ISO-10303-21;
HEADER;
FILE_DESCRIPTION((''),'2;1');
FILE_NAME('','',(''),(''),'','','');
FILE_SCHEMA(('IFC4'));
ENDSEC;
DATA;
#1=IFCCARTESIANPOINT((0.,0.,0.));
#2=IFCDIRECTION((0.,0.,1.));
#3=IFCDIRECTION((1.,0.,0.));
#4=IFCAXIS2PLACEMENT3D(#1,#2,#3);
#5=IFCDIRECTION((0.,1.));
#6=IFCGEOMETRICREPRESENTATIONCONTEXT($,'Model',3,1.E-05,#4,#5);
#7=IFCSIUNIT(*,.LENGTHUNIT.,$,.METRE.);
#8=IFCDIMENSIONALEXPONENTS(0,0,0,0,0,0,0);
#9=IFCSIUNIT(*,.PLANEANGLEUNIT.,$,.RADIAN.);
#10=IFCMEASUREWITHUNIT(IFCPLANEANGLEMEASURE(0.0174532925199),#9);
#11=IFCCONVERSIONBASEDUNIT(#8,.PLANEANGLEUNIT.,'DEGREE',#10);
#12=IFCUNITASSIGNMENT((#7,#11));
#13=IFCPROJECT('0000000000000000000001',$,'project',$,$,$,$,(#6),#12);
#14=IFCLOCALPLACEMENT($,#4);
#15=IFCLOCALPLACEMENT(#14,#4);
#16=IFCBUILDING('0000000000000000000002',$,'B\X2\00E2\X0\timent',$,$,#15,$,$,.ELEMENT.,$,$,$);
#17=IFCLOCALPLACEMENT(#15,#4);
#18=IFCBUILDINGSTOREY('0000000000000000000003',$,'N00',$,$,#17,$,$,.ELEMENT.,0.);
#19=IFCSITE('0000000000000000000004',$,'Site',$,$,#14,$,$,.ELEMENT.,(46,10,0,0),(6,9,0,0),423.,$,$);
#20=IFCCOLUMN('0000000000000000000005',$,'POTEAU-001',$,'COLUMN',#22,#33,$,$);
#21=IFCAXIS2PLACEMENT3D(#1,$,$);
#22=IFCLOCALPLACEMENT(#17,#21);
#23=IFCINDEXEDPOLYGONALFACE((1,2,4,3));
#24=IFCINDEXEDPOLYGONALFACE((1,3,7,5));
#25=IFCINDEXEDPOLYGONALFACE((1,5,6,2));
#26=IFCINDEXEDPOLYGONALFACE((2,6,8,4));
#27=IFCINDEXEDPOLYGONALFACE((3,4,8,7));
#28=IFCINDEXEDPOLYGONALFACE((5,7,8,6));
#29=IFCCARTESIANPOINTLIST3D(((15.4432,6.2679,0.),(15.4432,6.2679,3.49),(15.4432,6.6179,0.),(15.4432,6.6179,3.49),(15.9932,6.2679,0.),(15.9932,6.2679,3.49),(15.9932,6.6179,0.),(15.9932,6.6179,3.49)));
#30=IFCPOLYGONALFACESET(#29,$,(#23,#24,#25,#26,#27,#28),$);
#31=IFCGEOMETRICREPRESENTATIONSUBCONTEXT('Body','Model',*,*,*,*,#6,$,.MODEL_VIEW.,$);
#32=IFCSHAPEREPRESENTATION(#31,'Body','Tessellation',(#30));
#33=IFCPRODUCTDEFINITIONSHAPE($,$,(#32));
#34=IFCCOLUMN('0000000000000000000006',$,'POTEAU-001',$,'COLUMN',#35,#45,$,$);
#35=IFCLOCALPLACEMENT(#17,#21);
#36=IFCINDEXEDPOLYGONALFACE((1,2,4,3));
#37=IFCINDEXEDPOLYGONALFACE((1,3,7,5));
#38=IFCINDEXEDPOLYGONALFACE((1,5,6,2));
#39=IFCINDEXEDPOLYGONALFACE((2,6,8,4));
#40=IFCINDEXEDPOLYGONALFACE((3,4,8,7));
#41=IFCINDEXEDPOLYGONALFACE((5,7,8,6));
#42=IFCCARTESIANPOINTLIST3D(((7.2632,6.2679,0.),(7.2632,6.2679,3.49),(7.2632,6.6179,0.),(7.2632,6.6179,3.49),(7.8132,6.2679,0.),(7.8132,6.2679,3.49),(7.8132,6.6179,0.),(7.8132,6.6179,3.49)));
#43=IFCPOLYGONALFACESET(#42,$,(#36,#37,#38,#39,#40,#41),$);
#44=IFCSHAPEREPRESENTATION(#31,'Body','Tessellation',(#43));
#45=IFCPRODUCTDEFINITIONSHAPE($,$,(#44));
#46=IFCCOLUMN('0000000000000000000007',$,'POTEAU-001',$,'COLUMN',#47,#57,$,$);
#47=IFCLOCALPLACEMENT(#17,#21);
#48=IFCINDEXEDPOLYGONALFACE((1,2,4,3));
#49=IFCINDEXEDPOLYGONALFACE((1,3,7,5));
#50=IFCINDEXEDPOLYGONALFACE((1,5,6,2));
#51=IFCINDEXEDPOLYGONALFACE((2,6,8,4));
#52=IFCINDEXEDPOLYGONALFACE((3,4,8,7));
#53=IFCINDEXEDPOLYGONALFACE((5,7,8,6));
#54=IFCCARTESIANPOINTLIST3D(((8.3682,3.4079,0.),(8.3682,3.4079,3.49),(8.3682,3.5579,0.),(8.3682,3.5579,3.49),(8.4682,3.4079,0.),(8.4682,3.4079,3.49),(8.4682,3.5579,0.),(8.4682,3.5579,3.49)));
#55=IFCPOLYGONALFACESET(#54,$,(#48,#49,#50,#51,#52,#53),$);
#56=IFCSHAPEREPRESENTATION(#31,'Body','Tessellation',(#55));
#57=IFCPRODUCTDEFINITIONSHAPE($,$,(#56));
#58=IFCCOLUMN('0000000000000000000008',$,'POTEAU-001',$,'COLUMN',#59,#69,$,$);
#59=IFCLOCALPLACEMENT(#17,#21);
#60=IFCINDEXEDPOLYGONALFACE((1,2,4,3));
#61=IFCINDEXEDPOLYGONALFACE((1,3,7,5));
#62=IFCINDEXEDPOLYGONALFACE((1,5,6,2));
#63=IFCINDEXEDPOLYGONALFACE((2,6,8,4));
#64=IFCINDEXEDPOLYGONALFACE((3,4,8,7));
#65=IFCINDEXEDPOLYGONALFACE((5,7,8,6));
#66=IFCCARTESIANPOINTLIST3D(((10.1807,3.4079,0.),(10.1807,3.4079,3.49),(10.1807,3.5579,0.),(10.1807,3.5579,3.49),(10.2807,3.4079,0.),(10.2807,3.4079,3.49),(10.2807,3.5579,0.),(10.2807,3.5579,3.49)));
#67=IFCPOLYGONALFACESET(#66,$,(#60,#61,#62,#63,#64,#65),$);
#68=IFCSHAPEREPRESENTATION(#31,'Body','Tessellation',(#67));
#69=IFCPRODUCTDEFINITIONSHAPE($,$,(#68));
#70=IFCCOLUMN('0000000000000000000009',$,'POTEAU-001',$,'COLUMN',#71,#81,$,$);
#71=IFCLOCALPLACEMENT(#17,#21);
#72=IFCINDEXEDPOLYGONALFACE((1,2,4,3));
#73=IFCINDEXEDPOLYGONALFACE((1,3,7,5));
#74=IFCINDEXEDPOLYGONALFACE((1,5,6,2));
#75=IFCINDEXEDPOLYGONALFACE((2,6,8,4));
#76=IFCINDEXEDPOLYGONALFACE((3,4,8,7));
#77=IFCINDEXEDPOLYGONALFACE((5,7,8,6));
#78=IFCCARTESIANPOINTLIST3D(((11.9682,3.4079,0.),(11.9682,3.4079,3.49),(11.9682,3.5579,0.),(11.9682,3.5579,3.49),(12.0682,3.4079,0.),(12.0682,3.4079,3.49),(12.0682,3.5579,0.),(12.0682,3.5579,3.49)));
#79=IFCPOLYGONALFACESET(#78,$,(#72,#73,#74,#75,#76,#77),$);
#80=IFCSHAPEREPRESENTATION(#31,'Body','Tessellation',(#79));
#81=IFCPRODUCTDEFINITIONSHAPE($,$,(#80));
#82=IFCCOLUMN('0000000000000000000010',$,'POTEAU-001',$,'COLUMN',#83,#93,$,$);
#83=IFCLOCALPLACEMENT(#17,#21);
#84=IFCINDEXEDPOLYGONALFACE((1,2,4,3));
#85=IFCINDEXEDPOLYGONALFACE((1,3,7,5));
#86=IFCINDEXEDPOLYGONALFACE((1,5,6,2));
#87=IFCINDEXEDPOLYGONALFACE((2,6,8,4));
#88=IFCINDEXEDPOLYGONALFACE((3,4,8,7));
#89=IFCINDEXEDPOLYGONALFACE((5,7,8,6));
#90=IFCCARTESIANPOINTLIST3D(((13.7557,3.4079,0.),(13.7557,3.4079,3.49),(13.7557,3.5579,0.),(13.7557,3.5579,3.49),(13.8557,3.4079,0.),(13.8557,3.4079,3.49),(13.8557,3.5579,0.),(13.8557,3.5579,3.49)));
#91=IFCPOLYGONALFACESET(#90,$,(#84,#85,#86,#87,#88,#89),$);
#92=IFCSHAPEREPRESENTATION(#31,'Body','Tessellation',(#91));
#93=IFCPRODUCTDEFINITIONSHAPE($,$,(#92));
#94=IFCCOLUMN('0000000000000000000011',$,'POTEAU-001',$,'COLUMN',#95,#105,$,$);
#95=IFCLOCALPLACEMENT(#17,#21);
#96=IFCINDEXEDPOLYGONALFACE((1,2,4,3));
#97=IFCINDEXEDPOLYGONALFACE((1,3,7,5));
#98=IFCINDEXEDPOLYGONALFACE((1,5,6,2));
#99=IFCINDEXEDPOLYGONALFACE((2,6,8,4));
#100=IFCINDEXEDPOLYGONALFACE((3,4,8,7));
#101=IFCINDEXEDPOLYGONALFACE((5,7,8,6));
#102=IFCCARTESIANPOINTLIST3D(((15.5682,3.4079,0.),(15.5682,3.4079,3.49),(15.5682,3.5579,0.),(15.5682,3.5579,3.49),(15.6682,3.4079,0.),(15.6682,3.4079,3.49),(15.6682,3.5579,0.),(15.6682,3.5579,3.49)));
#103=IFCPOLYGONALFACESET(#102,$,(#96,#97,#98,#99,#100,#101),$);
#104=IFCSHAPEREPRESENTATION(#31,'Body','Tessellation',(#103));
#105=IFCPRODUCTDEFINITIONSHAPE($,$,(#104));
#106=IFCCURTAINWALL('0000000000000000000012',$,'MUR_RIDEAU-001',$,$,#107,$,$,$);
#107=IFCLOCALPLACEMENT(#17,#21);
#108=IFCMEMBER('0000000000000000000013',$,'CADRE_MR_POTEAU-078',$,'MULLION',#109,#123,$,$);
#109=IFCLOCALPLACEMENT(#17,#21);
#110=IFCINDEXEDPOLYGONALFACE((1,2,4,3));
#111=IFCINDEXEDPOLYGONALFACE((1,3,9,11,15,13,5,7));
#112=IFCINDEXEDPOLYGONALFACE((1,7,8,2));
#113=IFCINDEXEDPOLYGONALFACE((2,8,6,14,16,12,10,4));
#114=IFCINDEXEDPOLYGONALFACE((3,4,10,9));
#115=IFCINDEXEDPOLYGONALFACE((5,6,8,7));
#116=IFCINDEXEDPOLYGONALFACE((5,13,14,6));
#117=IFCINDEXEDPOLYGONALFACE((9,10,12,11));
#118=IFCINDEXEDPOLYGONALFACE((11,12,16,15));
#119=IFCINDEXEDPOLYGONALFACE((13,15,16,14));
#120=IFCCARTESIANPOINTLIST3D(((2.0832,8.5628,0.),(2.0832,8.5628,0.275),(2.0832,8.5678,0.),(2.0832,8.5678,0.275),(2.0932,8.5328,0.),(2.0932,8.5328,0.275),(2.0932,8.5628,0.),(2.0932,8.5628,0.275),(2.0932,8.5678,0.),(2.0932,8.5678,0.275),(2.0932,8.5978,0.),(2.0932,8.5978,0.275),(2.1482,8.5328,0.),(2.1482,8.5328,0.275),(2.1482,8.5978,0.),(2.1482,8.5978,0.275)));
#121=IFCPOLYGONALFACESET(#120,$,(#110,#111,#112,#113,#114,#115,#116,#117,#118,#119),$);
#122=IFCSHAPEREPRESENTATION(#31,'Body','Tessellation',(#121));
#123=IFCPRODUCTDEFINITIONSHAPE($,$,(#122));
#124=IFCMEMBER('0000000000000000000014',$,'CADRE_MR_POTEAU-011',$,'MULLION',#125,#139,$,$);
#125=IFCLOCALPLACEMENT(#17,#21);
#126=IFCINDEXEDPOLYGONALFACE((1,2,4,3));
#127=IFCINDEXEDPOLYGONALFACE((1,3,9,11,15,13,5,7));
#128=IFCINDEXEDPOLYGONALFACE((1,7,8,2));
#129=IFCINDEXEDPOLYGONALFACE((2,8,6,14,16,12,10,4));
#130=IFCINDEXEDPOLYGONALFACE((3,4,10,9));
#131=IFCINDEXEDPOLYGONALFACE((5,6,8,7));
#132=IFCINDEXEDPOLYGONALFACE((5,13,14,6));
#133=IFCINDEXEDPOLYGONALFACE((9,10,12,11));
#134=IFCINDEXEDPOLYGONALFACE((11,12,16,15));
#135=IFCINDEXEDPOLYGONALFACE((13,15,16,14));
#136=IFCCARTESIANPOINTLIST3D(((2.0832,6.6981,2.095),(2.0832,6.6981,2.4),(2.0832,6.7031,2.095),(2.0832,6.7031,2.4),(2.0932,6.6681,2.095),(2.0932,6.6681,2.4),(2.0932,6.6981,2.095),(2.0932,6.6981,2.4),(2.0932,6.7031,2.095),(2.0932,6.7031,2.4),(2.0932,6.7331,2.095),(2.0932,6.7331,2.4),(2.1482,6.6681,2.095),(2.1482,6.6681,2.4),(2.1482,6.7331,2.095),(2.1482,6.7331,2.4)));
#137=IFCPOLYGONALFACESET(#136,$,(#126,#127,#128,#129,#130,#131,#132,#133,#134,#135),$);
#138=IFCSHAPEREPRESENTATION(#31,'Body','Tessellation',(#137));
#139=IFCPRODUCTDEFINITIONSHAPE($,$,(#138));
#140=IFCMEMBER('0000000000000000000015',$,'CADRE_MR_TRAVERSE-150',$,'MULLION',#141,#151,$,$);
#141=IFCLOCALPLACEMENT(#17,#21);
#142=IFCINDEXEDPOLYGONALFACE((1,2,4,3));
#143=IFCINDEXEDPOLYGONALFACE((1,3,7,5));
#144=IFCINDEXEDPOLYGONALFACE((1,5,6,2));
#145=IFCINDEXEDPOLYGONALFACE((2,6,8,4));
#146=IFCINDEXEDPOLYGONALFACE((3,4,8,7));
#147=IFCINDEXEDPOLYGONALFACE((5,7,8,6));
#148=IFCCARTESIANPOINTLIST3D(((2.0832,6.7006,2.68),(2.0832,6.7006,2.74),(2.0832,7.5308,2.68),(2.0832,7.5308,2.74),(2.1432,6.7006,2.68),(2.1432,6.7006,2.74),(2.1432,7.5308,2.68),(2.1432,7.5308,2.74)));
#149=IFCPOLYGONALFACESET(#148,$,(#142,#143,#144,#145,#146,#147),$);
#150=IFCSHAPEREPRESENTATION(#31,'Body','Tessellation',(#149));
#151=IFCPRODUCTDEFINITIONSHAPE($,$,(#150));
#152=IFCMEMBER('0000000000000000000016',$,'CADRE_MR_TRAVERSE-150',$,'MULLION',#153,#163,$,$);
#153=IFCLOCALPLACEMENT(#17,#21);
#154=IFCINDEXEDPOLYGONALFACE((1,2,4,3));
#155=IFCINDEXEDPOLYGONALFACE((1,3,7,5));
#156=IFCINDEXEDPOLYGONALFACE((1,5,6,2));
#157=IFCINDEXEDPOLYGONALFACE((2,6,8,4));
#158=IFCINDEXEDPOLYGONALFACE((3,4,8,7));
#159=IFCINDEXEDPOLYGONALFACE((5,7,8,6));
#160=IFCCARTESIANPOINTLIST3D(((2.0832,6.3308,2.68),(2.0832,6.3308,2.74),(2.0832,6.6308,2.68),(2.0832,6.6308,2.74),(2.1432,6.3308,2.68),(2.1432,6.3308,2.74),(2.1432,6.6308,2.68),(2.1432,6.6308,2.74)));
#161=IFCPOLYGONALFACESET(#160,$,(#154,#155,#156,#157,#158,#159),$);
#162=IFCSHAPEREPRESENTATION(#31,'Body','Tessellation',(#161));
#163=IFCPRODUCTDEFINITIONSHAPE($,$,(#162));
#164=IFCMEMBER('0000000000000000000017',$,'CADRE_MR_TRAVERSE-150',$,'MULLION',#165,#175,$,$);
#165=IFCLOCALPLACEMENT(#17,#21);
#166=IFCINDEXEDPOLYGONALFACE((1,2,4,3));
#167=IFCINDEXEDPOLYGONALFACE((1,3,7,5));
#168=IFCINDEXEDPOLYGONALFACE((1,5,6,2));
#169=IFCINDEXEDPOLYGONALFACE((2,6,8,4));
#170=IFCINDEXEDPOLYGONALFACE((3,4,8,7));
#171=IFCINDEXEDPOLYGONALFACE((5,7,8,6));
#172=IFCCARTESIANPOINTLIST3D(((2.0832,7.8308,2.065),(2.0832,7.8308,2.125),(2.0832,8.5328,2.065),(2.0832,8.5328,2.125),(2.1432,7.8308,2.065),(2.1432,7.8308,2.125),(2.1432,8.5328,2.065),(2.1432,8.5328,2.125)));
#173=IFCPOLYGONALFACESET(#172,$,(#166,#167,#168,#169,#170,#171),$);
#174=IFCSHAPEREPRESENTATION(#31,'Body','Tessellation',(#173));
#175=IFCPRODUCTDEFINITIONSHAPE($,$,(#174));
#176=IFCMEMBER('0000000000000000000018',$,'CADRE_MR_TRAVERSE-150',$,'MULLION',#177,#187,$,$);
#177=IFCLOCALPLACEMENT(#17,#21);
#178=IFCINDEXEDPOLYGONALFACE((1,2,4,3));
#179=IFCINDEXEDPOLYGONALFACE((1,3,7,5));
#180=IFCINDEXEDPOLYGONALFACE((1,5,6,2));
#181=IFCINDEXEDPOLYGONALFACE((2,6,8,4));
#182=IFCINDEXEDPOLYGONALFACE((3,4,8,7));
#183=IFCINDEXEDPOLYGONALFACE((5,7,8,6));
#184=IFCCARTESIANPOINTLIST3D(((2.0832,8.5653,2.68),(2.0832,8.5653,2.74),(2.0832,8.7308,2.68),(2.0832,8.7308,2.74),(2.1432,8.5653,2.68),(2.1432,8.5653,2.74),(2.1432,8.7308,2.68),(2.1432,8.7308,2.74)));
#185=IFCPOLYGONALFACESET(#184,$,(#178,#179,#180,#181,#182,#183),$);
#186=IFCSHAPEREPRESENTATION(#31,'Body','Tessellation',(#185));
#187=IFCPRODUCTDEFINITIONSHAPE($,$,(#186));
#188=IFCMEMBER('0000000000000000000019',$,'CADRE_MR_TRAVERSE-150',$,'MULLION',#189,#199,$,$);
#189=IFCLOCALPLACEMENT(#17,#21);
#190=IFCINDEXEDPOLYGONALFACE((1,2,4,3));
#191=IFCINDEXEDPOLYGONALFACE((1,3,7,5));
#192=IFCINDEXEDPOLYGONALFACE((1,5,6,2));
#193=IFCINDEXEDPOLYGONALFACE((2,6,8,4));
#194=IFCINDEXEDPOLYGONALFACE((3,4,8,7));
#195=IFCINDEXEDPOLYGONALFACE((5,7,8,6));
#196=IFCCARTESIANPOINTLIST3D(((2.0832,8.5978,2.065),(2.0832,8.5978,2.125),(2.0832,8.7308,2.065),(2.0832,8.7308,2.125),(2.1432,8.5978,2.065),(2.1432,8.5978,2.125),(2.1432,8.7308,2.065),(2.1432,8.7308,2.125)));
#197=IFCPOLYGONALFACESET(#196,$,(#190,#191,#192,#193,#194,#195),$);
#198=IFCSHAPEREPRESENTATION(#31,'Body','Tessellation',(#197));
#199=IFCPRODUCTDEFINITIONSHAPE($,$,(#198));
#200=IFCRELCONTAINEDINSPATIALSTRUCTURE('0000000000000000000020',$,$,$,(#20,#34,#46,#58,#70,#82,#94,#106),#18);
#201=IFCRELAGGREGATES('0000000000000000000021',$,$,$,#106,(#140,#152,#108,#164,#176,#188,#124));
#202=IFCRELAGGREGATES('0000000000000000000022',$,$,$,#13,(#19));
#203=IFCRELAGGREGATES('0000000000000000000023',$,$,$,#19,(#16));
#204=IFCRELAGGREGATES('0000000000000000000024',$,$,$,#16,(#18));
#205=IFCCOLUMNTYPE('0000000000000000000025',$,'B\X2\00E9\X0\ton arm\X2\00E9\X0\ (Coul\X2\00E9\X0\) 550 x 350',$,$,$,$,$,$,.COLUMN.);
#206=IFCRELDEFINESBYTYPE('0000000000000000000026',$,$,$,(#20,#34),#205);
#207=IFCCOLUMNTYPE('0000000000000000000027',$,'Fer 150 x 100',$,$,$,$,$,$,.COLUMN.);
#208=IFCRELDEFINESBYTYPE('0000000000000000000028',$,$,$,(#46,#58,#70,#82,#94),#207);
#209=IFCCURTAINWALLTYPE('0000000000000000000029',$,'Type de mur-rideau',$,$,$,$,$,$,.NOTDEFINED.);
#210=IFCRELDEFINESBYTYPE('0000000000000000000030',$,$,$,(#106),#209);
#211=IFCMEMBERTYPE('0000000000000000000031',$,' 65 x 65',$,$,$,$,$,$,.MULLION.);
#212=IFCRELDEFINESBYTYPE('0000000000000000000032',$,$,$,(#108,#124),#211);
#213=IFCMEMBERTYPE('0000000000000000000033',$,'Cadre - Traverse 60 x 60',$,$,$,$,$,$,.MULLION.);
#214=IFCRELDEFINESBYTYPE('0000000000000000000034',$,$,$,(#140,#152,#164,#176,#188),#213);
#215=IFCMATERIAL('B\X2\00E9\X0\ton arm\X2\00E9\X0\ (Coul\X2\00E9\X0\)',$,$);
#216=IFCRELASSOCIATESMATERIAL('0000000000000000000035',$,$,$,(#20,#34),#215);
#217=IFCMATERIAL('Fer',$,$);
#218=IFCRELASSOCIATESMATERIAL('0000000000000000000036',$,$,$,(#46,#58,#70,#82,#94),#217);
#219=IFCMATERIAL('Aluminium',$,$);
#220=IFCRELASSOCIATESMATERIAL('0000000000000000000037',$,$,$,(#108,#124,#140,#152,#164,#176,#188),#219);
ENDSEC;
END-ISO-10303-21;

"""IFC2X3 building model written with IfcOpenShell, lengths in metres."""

from ifc_helpers import new_model, entity, si_unit, converted_unit, direction, frame, origin_with_axes, origin_2d_with_axis, place, context, subcontext, project, spatial, polyline, rectangle, outline, extrude, material, type_object, element, aggregate, save


model = new_model("IFC2X3")

# Units and contexts
model_context = context("Model", 3, precision=1e-05, world=origin_with_axes(), true_north=direction((0.0, 1.0)))
body_context = subcontext(model_context, "Body", "Model", "MODEL_VIEW")
ifc_project = project(units=[si_unit("LENGTHUNIT", "METRE"), converted_unit("PLANEANGLEUNIT", "DEGREE", entity("IfcPlaneAngleMeasure", 0.0174532925199), si_unit("PLANEANGLEUNIT", "RADIAN"), dimensions=[0, 0, 0, 0, 0, 0, 0])], contexts=[model_context])

# Site, building, storey
site_placement = place(None, origin_with_axes())
site = spatial("IfcSite", under=ifc_project, at=site_placement, Name="Site", CompositionType="ELEMENT", RefLatitude=(46, 10, 0, 0), RefLongitude=(6, 9, 0, 0), RefElevation=423.0)
building_placement = place(site_placement, origin_with_axes())
building = spatial("IfcBuilding", under=site, at=building_placement, Name="Bâtiment", CompositionType="ELEMENT")
storey_placement = place(building_placement, origin_with_axes())
storey = spatial("IfcBuildingStorey", under=building, at=storey_placement, Name="N00", CompositionType="ELEMENT", Elevation=0.0)

# Columns
ifc_material_1 = material(Name="Béton armé (Coulé)")
column_type_1 = type_object("IfcColumnType", Name="Béton armé (Coulé) 550 x 350", PredefinedType="COLUMN")
for number, where, z_axis, x_axis, name in (
    (1, (15.7182, 6.4429, 0.0), (0.0, 0.0, 1.0), (1.0, 0.0, 0.0), "POTEAU-001"),
    (2, (7.5382, 6.4429, 0.0), (0.0, 0.0, 1.0), (1.0, 0.0, 0.0), "POTEAU-001"),
):
    element("IfcColumn", number, at=place(storey_placement, frame(where, z_axis=z_axis, x_axis=x_axis)), inside=storey, type_object=column_type_1, material=ifc_material_1, Name=name, ObjectType="COLUMN", context=body_context, shape_type="SweptSolid", body=[
        extrude(rectangle(XDim=0.55, YDim=0.35, at=origin_2d_with_axis()), origin_with_axes(), (0.0, 0.0, 1.0), 3.49),
    ])
ifc_material_2 = material(Name="Fer")
column_type_2 = type_object("IfcColumnType", Name="Fer 150 x 100", PredefinedType="COLUMN")
for number, where, z_axis, x_axis, name in (
    (3, (8.4182, 3.4829, 0.0), (0.0, 0.0, 1.0), (0.0, 1.0, 0.0), "POTEAU-001"),
    (4, (10.2307, 3.4829, 0.0), (0.0, 0.0, 1.0), (0.0, 1.0, 0.0), "POTEAU-001"),
    (5, (12.0182, 3.4829, 0.0), (0.0, 0.0, 1.0), (0.0, 1.0, 0.0), "POTEAU-001"),
    (6, (13.8057, 3.4829, 0.0), (0.0, 0.0, 1.0), (0.0, 1.0, 0.0), "POTEAU-001"),
    (7, (15.6182, 3.4829, 0.0), (0.0, 0.0, 1.0), (0.0, 1.0, 0.0), "POTEAU-001"),
):
    element("IfcColumn", number, at=place(storey_placement, frame(where, z_axis=z_axis, x_axis=x_axis)), inside=storey, type_object=column_type_2, material=ifc_material_2, Name=name, ObjectType="COLUMN", context=body_context, shape_type="SweptSolid", body=[
        extrude(rectangle(XDim=0.15, YDim=0.1, at=origin_2d_with_axis()), origin_with_axes(), (0.0, 0.0, 1.0), 3.49),
    ])

# Curtain wall, members
curtain_wall_type = type_object("IfcCurtainWallType", Name="Type de mur-rideau", PredefinedType="NOTDEFINED")
curtain_wall_placement = place(storey_placement, frame((2.0832, 6.4208, 0.0), z_axis=(0.0, 0.0, 1.0), x_axis=(1.0, 0.0, 0.0)))
curtain_wall = element("IfcCurtainWall", 8, at=curtain_wall_placement, inside=storey, type_object=curtain_wall_type, Name="MUR_RIDEAU-001")
ifc_material_3 = material(Name="Aluminium")
member_type_1 = type_object("IfcMemberType", Name=" 65 x 65", PredefinedType="MULLION")
member_1_placement = place(curtain_wall_placement, frame((0.0, 2.1445, 0.0), z_axis=(0.0, 0.0, 1.0), x_axis=(0.0, 1.0, 0.0)))
member_1 = element("IfcMember", 9, at=member_1_placement, type_object=member_type_1, material=ifc_material_3, Name="CADRE_MR_POTEAU-078", ObjectType="MULLION", context=body_context, shape_type="SweptSolid", body=[
    extrude(outline(polyline([(0.01, -0.0025), (0.01, -0.0325), (0.065, -0.0325), (0.065, 0.0325), (0.01, 0.0325), (0.01, 0.0025), (0.0, 0.0025), (0.0, -0.0025), (0.01, -0.0025)])), frame((0.0, 0.0, 0.0), z_axis=(0.0, 0.0, 1.0), x_axis=(0.0, -1.0, 0.0)), (0.0, 0.0, 1.0), 0.275),
])
member_2_placement = place(curtain_wall_placement, frame((0.0, 0.2798, 2.095), z_axis=(0.0, 0.0, 1.0), x_axis=(0.0, 1.0, 0.0)))
member_2 = element("IfcMember", 10, at=member_2_placement, type_object=member_type_1, material=ifc_material_3, Name="CADRE_MR_POTEAU-011", ObjectType="MULLION", context=body_context, shape_type="SweptSolid", body=[
    extrude(outline(polyline([(0.01, -0.0025), (0.01, -0.0325), (0.065, -0.0325), (0.065, 0.0325), (0.01, 0.0325), (0.01, 0.0025), (0.0, 0.0025), (0.0, -0.0025), (0.01, -0.0025)])), frame((0.0, 0.0, 0.0), z_axis=(0.0, 0.0, 1.0), x_axis=(0.0, -1.0, 0.0)), (0.0, 0.0, 1.0), 0.305),
])
member_type_2 = type_object("IfcMemberType", Name="Cadre - Traverse 60 x 60", PredefinedType="MULLION")
member_3_placement = place(curtain_wall_placement, frame((0.0, 1.1099, 2.71), z_axis=(0.0, -1.0, 0.0), x_axis=(0.0, 0.0, 1.0)))
member_3 = element("IfcMember", 11, at=member_3_placement, type_object=member_type_2, material=ifc_material_3, Name="CADRE_MR_TRAVERSE-150", ObjectType="MULLION", context=body_context, shape_type="SweptSolid", body=[
    extrude(outline(polyline([(-0.06, -0.03), (0.0, -0.03), (0.0, 0.03), (-0.06, 0.03), (-0.06, -0.03)])), frame((0.0, 0.0, 0.0), z_axis=(0.0, 0.0, 1.0), x_axis=(0.0, 1.0, 0.0)), (0.0, 0.0, 1.0), 0.8301),
])
member_4_placement = place(curtain_wall_placement, frame((0.0, 0.2099, 2.71), z_axis=(0.0, -1.0, 0.0), x_axis=(0.0, 0.0, 1.0)))
member_4 = element("IfcMember", 12, at=member_4_placement, type_object=member_type_2, material=ifc_material_3, Name="CADRE_MR_TRAVERSE-150", ObjectType="MULLION", context=body_context, shape_type="SweptSolid", body=[
    extrude(outline(polyline([(-0.06, -0.03), (0.0, -0.03), (0.0, 0.03), (-0.06, 0.03), (-0.06, -0.03)])), frame((0.0, 0.0, 0.0), z_axis=(0.0, 0.0, 1.0), x_axis=(0.0, 1.0, 0.0)), (0.0, 0.0, 1.0), 0.3),
])
member_5_placement = place(curtain_wall_placement, frame((0.0, 2.1445, 2.095), z_axis=(0.0, -1.0, 0.0), x_axis=(0.0, 0.0, 1.0)))
member_5 = element("IfcMember", 13, at=member_5_placement, type_object=member_type_2, material=ifc_material_3, Name="CADRE_MR_TRAVERSE-150", ObjectType="MULLION", context=body_context, shape_type="SweptSolid", body=[
    extrude(outline(polyline([(-0.06, -0.03), (0.0, -0.03), (0.0, 0.03), (-0.06, 0.03), (-0.06, -0.03)])), frame((0.0, 0.0, 0.0325), z_axis=(0.0, 0.0, 1.0), x_axis=(0.0, 1.0, 0.0)), (0.0, 0.0, 1.0), 0.7021),
])
member_6_placement = place(curtain_wall_placement, frame((0.0, 2.3099, 2.71), z_axis=(0.0, -1.0, 0.0), x_axis=(0.0, 0.0, 1.0)))
member_6 = element("IfcMember", 14, at=member_6_placement, type_object=member_type_2, material=ifc_material_3, Name="CADRE_MR_TRAVERSE-150", ObjectType="MULLION", context=body_context, shape_type="SweptSolid", body=[
    extrude(outline(polyline([(-0.06, -0.03), (0.0, -0.03), (0.0, 0.03), (-0.06, 0.03), (-0.06, -0.03)])), frame((0.0, 0.0, 0.0), z_axis=(0.0, 0.0, 1.0), x_axis=(0.0, 1.0, 0.0)), (0.0, 0.0, 1.0), 0.1654),
])
member_7_placement = place(curtain_wall_placement, frame((0.0, 2.3099, 2.095), z_axis=(0.0, -1.0, 0.0), x_axis=(0.0, 0.0, 1.0)))
member_7 = element("IfcMember", 15, at=member_7_placement, type_object=member_type_2, material=ifc_material_3, Name="CADRE_MR_TRAVERSE-150", ObjectType="MULLION", context=body_context, shape_type="SweptSolid", body=[
    extrude(outline(polyline([(-0.06, -0.03), (0.0, -0.03), (0.0, 0.03), (-0.06, 0.03), (-0.06, -0.03)])), frame((0.0, 0.0, 0.0), z_axis=(0.0, 0.0, 1.0), x_axis=(0.0, 1.0, 0.0)), (0.0, 0.0, 1.0), 0.1329),
])
aggregate(curtain_wall, [member_3, member_4, member_1, member_5, member_6, member_7, member_2])

save(model, "model.ifc")
